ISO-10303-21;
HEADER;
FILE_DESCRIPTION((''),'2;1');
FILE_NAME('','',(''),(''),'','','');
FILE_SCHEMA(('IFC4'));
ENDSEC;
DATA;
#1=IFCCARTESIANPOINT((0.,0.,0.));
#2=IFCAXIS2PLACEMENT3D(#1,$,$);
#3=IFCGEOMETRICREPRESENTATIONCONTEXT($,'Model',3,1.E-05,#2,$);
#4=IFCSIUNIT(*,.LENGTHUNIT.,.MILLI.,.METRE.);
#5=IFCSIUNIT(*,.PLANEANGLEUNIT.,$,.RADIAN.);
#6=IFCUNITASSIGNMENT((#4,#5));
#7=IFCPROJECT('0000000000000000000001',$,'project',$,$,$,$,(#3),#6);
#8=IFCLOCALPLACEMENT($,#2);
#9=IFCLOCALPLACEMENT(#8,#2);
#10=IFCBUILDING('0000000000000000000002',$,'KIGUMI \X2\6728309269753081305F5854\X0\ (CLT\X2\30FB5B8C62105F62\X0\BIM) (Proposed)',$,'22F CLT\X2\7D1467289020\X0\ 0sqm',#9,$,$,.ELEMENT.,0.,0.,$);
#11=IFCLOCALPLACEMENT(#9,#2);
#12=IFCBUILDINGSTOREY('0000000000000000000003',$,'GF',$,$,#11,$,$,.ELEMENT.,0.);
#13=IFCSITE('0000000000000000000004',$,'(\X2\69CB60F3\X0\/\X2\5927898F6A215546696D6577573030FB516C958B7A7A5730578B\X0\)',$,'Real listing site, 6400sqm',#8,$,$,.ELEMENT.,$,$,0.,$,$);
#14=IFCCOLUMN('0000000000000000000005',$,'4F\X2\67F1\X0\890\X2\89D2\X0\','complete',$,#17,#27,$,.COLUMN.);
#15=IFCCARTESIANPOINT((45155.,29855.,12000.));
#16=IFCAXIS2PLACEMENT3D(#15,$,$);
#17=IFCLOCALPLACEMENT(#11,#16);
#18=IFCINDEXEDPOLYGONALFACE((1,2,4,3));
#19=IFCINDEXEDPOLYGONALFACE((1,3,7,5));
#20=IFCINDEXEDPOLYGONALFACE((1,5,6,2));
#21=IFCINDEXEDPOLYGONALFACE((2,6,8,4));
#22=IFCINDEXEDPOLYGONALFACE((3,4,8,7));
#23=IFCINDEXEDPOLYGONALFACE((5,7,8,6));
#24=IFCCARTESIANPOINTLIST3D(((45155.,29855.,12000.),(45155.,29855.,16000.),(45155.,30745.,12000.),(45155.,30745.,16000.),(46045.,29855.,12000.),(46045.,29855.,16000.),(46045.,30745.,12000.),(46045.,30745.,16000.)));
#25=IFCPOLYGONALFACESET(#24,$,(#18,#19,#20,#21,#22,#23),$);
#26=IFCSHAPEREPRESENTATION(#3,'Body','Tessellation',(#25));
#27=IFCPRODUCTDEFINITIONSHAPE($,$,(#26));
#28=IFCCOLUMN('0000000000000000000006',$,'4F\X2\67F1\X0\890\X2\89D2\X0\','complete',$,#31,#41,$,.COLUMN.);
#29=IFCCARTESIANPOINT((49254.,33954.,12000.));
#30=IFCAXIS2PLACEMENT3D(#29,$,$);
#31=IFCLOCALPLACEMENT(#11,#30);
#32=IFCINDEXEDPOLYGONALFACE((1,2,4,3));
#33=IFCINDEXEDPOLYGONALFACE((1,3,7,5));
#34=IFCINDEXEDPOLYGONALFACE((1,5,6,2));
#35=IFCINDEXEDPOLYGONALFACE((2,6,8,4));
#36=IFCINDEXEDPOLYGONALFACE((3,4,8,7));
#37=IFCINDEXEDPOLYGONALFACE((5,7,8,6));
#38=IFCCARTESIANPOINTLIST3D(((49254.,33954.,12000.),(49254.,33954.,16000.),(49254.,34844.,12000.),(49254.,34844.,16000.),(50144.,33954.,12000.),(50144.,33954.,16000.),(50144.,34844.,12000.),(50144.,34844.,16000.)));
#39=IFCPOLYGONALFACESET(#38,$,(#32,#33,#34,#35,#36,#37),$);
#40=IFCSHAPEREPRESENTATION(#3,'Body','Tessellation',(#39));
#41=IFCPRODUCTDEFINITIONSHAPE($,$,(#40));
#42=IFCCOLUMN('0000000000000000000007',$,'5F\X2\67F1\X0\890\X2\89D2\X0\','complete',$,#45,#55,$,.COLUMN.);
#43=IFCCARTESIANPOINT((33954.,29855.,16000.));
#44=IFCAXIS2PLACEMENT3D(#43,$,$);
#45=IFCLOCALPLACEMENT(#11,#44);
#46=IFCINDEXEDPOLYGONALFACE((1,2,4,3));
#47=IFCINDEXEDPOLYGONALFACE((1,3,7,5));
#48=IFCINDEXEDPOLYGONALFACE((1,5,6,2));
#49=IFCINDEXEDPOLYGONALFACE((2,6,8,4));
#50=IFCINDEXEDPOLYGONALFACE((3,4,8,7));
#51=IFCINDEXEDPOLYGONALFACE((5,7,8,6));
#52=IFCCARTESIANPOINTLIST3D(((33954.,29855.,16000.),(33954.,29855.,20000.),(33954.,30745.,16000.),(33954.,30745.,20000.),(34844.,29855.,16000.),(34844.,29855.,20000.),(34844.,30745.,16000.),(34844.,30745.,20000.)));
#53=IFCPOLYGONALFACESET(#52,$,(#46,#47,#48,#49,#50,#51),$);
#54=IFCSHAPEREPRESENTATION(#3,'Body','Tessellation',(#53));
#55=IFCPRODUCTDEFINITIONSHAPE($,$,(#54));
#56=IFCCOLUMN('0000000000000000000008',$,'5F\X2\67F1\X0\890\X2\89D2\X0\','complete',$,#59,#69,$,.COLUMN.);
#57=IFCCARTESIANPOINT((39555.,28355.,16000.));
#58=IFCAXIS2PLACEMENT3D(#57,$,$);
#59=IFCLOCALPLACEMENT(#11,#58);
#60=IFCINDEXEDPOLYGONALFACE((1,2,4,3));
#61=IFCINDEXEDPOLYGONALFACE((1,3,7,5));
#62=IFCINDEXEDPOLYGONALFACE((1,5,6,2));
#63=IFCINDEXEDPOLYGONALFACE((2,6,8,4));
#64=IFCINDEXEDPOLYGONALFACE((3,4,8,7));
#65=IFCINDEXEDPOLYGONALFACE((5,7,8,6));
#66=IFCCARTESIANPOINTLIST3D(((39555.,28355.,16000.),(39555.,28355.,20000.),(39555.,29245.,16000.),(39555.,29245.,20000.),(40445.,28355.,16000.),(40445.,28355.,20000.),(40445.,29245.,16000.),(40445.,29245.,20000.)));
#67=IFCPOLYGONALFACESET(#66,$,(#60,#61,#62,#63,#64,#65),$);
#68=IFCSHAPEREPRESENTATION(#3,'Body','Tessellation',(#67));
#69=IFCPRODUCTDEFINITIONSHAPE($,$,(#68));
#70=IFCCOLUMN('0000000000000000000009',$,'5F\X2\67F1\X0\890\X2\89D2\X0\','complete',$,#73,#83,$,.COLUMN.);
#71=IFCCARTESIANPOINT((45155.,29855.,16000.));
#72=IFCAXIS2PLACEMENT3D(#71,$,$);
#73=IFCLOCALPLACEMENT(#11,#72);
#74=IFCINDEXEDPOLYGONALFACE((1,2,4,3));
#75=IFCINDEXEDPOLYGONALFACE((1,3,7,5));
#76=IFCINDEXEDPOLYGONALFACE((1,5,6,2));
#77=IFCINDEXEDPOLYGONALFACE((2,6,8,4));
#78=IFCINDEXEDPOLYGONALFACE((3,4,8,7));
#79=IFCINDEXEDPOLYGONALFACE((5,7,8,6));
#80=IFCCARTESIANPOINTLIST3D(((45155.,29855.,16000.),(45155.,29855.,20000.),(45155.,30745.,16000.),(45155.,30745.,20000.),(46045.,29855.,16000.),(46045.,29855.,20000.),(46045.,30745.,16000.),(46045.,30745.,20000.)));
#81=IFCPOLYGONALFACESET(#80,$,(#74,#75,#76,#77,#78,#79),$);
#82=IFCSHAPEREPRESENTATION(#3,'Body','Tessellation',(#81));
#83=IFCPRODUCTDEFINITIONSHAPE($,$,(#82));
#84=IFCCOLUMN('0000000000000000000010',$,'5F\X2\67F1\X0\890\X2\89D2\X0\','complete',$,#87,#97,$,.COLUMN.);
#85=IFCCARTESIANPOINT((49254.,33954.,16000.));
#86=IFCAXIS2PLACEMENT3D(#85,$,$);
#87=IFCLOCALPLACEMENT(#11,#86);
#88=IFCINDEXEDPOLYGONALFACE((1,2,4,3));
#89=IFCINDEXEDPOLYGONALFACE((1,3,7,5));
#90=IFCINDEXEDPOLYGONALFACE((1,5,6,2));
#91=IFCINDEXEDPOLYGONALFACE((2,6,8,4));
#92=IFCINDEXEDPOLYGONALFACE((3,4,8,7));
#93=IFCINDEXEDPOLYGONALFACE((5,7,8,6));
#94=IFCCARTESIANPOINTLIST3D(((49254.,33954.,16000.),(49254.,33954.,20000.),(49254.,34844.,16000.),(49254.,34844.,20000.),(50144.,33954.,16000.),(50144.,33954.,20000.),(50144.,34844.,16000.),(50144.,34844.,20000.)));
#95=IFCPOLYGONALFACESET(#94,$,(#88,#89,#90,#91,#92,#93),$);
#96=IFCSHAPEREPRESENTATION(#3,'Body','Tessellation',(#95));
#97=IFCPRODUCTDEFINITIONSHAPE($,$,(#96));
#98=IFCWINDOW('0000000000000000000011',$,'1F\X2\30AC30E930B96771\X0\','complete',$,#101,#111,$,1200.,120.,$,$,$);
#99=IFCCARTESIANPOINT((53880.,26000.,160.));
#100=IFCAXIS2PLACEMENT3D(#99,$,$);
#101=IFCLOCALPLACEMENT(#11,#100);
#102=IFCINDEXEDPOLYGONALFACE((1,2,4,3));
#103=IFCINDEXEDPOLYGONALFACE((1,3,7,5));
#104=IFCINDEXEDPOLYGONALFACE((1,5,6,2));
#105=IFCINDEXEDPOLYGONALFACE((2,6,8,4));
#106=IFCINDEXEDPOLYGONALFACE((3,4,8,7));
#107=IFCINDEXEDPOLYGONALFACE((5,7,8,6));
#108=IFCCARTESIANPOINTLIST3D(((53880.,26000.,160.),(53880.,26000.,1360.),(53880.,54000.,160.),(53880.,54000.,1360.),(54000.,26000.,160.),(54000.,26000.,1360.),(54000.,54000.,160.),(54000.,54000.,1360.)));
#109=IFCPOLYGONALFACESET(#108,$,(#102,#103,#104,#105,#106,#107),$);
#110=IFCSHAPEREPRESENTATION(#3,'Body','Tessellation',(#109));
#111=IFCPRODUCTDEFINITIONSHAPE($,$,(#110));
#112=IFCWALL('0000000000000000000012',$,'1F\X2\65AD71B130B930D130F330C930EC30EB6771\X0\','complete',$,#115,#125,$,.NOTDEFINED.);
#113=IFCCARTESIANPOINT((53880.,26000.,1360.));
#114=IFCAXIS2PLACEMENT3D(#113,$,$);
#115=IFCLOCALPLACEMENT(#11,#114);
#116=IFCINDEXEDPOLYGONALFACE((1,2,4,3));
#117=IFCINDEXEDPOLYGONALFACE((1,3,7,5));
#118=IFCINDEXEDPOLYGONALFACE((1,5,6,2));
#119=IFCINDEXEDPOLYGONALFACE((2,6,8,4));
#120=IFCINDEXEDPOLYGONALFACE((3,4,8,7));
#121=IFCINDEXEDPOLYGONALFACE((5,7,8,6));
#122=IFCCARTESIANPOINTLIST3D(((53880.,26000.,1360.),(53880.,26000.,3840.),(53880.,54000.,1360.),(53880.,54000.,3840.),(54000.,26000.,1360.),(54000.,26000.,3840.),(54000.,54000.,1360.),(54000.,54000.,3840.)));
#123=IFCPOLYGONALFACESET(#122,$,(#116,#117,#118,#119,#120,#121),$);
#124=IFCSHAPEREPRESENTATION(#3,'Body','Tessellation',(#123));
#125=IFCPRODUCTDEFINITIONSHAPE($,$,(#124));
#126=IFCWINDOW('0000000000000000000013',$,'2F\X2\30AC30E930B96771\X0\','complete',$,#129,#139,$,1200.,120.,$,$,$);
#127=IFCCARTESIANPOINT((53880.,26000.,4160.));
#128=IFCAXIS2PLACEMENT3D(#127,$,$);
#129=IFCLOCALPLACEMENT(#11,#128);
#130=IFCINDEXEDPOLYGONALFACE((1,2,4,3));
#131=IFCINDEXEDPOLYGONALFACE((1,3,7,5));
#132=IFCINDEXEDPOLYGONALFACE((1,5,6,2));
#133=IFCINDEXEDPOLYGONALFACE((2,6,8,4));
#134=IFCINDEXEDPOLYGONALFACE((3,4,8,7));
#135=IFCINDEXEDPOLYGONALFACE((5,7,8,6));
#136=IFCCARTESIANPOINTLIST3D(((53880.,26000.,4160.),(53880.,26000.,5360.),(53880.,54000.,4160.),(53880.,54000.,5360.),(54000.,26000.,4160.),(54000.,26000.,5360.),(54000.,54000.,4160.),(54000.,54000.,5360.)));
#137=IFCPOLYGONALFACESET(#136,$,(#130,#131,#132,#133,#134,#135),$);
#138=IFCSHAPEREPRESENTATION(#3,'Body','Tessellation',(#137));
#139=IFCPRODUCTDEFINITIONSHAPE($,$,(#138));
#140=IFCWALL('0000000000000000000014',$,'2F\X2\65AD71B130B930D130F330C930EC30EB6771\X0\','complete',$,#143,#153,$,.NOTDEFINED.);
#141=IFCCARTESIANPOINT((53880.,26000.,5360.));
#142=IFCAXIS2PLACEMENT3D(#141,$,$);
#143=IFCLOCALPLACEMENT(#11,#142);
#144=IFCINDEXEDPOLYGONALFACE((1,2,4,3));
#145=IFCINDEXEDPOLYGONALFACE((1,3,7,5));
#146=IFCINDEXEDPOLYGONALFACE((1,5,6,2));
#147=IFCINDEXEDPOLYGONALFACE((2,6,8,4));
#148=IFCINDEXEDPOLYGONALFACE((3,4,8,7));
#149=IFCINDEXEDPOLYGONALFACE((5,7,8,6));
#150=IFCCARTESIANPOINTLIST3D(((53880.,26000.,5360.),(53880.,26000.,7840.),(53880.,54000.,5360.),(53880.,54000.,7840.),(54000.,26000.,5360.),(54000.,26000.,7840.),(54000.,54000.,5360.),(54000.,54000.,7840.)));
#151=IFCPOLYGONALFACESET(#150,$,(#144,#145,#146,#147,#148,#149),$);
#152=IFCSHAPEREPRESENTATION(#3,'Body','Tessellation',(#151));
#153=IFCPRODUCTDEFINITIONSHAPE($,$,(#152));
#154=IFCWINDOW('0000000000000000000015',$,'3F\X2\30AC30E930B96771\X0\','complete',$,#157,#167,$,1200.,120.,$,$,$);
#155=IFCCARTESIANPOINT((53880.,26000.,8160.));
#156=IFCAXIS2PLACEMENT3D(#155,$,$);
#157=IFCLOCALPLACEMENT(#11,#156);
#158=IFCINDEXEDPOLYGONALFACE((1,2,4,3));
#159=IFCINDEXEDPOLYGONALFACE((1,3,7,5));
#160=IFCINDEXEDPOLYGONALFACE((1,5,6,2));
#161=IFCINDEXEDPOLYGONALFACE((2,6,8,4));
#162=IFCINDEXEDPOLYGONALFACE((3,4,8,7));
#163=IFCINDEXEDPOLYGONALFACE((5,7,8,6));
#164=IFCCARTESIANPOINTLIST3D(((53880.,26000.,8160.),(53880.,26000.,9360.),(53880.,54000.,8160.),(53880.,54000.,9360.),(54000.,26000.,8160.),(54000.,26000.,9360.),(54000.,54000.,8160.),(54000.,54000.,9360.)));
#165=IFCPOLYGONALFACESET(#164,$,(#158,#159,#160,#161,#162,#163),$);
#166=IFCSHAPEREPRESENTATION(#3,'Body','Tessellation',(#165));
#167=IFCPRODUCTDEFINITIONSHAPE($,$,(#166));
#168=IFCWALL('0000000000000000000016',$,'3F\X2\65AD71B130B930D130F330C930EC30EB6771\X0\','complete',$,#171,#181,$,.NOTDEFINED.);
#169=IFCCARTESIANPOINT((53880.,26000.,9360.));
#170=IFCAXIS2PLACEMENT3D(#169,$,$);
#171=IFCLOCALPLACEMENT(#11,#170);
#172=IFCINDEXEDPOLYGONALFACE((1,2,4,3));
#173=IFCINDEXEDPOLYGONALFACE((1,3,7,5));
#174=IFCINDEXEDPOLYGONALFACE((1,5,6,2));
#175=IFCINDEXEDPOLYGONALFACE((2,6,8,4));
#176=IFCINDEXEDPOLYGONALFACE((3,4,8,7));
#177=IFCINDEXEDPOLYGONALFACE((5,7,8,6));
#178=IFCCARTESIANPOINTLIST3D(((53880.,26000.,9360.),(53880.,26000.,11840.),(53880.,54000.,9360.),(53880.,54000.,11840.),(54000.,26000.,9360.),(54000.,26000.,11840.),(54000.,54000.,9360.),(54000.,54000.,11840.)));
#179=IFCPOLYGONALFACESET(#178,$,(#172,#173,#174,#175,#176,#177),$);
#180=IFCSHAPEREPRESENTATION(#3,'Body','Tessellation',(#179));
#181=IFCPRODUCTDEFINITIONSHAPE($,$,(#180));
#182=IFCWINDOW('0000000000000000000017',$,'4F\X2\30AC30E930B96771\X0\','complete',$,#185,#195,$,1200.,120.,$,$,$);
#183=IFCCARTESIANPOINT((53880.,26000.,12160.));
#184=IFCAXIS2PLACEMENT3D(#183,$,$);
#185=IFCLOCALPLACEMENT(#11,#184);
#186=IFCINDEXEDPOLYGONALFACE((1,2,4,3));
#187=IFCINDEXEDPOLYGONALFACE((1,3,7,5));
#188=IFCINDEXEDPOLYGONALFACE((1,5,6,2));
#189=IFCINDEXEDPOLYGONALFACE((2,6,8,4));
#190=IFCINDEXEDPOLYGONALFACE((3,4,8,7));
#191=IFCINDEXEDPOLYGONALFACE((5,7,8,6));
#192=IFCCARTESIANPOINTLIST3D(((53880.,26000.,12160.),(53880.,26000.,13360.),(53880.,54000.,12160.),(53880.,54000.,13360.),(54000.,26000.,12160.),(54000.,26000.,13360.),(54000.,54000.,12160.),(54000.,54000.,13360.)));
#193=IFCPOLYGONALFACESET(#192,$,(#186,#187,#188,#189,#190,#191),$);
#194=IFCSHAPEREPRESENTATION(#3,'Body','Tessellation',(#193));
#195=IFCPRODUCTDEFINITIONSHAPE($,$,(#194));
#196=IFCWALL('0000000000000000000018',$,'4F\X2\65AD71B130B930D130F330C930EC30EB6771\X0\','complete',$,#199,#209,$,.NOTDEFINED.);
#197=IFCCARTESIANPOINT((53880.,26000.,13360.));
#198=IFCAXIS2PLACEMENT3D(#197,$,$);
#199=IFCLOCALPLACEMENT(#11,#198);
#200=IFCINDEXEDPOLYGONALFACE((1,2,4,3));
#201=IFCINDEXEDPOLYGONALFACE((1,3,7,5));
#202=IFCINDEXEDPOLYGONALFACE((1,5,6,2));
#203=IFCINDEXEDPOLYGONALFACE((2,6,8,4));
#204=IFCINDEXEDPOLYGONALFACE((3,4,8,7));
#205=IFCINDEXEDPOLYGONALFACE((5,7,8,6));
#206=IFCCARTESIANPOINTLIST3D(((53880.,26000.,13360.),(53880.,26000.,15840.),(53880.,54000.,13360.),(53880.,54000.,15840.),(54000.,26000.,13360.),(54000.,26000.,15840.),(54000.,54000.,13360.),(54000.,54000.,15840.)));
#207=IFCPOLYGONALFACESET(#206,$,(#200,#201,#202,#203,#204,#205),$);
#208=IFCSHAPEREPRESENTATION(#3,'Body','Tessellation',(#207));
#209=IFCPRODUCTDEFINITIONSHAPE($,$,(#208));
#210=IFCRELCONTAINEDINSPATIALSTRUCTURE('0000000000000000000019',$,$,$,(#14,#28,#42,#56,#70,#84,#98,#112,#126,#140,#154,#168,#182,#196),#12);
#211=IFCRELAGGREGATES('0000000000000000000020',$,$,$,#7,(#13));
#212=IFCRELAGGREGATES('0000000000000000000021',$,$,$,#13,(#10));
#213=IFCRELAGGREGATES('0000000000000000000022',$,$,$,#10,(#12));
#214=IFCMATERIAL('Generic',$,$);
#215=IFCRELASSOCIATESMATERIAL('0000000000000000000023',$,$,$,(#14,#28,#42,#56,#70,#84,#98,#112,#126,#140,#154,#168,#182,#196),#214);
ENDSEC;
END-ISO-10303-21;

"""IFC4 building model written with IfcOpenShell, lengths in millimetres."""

from ifc_helpers import new_model, si_unit, frame, frame_2d, origin, place, context, project, spatial, rectangle, extrude, material, element, save


model = new_model("IFC4")

# Units and contexts
model_context = context("Model", 3, precision=1e-05, world=origin())
ifc_project = project(units=[si_unit("LENGTHUNIT", "METRE", prefix="MILLI"), si_unit("PLANEANGLEUNIT", "RADIAN")], contexts=[model_context])

# Site, building, storey
site_placement = place(None, origin())
site = spatial("IfcSite", under=ifc_project, at=site_placement, Name="(構想/大規模商業敷地・公開空地型)", ObjectType="Real listing site, 6400sqm", CompositionType="ELEMENT", RefElevation=0.0)
building_placement = place(site_placement, origin())
building = spatial("IfcBuilding", under=site, at=building_placement, Name="KIGUMI 木を極めた塔 (CLT・完成形BIM) (Proposed)", ObjectType="22F CLT純木造 0sqm", CompositionType="ELEMENT", ElevationOfRefHeight=0.0, ElevationOfTerrain=0.0)
storey_placement = place(building_placement, origin())
storey = spatial("IfcBuildingStorey", under=building, at=storey_placement, Name="GF", CompositionType="ELEMENT", Elevation=0.0)

# Columns
ifc_material = material(Name="Generic")
column_1_placement = place(storey_placement, frame((45155.0, 29855.0, 12000.0)))
element("IfcColumn", 1, at=column_1_placement, inside=storey, material=ifc_material, Name="4F柱890角", Description="complete", PredefinedType="COLUMN", context=model_context, shape_type="SweptSolid", body=[
    extrude(rectangle(XDim=890.0, YDim=890.0, at=frame_2d((445.0, 445.0))), frame((45155.0, 29855.0, 12000.0)), (0.0, 0.0, 1.0), 4000.0),
])
column_2_placement = place(storey_placement, frame((49254.0, 33954.0, 12000.0)))
element("IfcColumn", 2, at=column_2_placement, inside=storey, material=ifc_material, Name="4F柱890角", Description="complete", PredefinedType="COLUMN", context=model_context, shape_type="SweptSolid", body=[
    extrude(rectangle(XDim=890.0, YDim=890.0, at=frame_2d((445.0, 445.0))), frame((49254.0, 33954.0, 12000.0)), (0.0, 0.0, 1.0), 4000.0),
])
column_3_placement = place(storey_placement, frame((33954.0, 29855.0, 16000.0)))
element("IfcColumn", 3, at=column_3_placement, inside=storey, material=ifc_material, Name="5F柱890角", Description="complete", PredefinedType="COLUMN", context=model_context, shape_type="SweptSolid", body=[
    extrude(rectangle(XDim=890.0, YDim=890.0, at=frame_2d((445.0, 445.0))), frame((33954.0, 29855.0, 16000.0)), (0.0, 0.0, 1.0), 4000.0),
])
column_4_placement = place(storey_placement, frame((39555.0, 28355.0, 16000.0)))
element("IfcColumn", 4, at=column_4_placement, inside=storey, material=ifc_material, Name="5F柱890角", Description="complete", PredefinedType="COLUMN", context=model_context, shape_type="SweptSolid", body=[
    extrude(rectangle(XDim=890.0, YDim=890.0, at=frame_2d((445.0, 445.0))), frame((39555.0, 28355.0, 16000.0)), (0.0, 0.0, 1.0), 4000.0),
])
column_5_placement = place(storey_placement, frame((45155.0, 29855.0, 16000.0)))
element("IfcColumn", 5, at=column_5_placement, inside=storey, material=ifc_material, Name="5F柱890角", Description="complete", PredefinedType="COLUMN", context=model_context, shape_type="SweptSolid", body=[
    extrude(rectangle(XDim=890.0, YDim=890.0, at=frame_2d((445.0, 445.0))), frame((45155.0, 29855.0, 16000.0)), (0.0, 0.0, 1.0), 4000.0),
])
column_6_placement = place(storey_placement, frame((49254.0, 33954.0, 16000.0)))
element("IfcColumn", 6, at=column_6_placement, inside=storey, material=ifc_material, Name="5F柱890角", Description="complete", PredefinedType="COLUMN", context=model_context, shape_type="SweptSolid", body=[
    extrude(rectangle(XDim=890.0, YDim=890.0, at=frame_2d((445.0, 445.0))), frame((49254.0, 33954.0, 16000.0)), (0.0, 0.0, 1.0), 4000.0),
])

# Window
window_1_placement = place(storey_placement, frame((53880.0, 26000.0, 160.0)))
element("IfcWindow", 7, at=window_1_placement, inside=storey, material=ifc_material, Name="1Fガラス東", Description="complete", OverallHeight=1200.0, OverallWidth=120.0, context=model_context, shape_type="SweptSolid", body=[
    extrude(rectangle(XDim=120.0, YDim=28000.0, at=frame_2d((60.0, 14000.0))), frame((53880.0, 26000.0, 160.0)), (0.0, 0.0, 1.0), 1200.0),
])

# Wall
wall_1_placement = place(storey_placement, frame((53880.0, 26000.0, 1360.0)))
element("IfcWall", 8, at=wall_1_placement, inside=storey, material=ifc_material, Name="1F断熱スパンドレル東", Description="complete", PredefinedType="NOTDEFINED", context=model_context, shape_type="SweptSolid", body=[
    extrude(rectangle(XDim=120.0, YDim=28000.0, at=frame_2d((60.0, 14000.0))), frame((53880.0, 26000.0, 1360.0)), (0.0, 0.0, 1.0), 2480.0),
])

# Window
window_2_placement = place(storey_placement, frame((53880.0, 26000.0, 4160.0)))
element("IfcWindow", 9, at=window_2_placement, inside=storey, material=ifc_material, Name="2Fガラス東", Description="complete", OverallHeight=1200.0, OverallWidth=120.0, context=model_context, shape_type="SweptSolid", body=[
    extrude(rectangle(XDim=120.0, YDim=28000.0, at=frame_2d((60.0, 14000.0))), frame((53880.0, 26000.0, 4160.0)), (0.0, 0.0, 1.0), 1200.0),
])

# Wall
wall_2_placement = place(storey_placement, frame((53880.0, 26000.0, 5360.0)))
element("IfcWall", 10, at=wall_2_placement, inside=storey, material=ifc_material, Name="2F断熱スパンドレル東", Description="complete", PredefinedType="NOTDEFINED", context=model_context, shape_type="SweptSolid", body=[
    extrude(rectangle(XDim=120.0, YDim=28000.0, at=frame_2d((60.0, 14000.0))), frame((53880.0, 26000.0, 5360.0)), (0.0, 0.0, 1.0), 2480.0),
])

# Window
window_3_placement = place(storey_placement, frame((53880.0, 26000.0, 8160.0)))
element("IfcWindow", 11, at=window_3_placement, inside=storey, material=ifc_material, Name="3Fガラス東", Description="complete", OverallHeight=1200.0, OverallWidth=120.0, context=model_context, shape_type="SweptSolid", body=[
    extrude(rectangle(XDim=120.0, YDim=28000.0, at=frame_2d((60.0, 14000.0))), frame((53880.0, 26000.0, 8160.0)), (0.0, 0.0, 1.0), 1200.0),
])

# Wall
wall_3_placement = place(storey_placement, frame((53880.0, 26000.0, 9360.0)))
element("IfcWall", 12, at=wall_3_placement, inside=storey, material=ifc_material, Name="3F断熱スパンドレル東", Description="complete", PredefinedType="NOTDEFINED", context=model_context, shape_type="SweptSolid", body=[
    extrude(rectangle(XDim=120.0, YDim=28000.0, at=frame_2d((60.0, 14000.0))), frame((53880.0, 26000.0, 9360.0)), (0.0, 0.0, 1.0), 2480.0),
])

# Window
window_4_placement = place(storey_placement, frame((53880.0, 26000.0, 12160.0)))
element("IfcWindow", 13, at=window_4_placement, inside=storey, material=ifc_material, Name="4Fガラス東", Description="complete", OverallHeight=1200.0, OverallWidth=120.0, context=model_context, shape_type="SweptSolid", body=[
    extrude(rectangle(XDim=120.0, YDim=28000.0, at=frame_2d((60.0, 14000.0))), frame((53880.0, 26000.0, 12160.0)), (0.0, 0.0, 1.0), 1200.0),
])

# Wall
wall_4_placement = place(storey_placement, frame((53880.0, 26000.0, 13360.0)))
element("IfcWall", 14, at=wall_4_placement, inside=storey, material=ifc_material, Name="4F断熱スパンドレル東", Description="complete", PredefinedType="NOTDEFINED", context=model_context, shape_type="SweptSolid", body=[
    extrude(rectangle(XDim=120.0, YDim=28000.0, at=frame_2d((60.0, 14000.0))), frame((53880.0, 26000.0, 13360.0)), (0.0, 0.0, 1.0), 2480.0),
])

save(model, "model.ifc")
